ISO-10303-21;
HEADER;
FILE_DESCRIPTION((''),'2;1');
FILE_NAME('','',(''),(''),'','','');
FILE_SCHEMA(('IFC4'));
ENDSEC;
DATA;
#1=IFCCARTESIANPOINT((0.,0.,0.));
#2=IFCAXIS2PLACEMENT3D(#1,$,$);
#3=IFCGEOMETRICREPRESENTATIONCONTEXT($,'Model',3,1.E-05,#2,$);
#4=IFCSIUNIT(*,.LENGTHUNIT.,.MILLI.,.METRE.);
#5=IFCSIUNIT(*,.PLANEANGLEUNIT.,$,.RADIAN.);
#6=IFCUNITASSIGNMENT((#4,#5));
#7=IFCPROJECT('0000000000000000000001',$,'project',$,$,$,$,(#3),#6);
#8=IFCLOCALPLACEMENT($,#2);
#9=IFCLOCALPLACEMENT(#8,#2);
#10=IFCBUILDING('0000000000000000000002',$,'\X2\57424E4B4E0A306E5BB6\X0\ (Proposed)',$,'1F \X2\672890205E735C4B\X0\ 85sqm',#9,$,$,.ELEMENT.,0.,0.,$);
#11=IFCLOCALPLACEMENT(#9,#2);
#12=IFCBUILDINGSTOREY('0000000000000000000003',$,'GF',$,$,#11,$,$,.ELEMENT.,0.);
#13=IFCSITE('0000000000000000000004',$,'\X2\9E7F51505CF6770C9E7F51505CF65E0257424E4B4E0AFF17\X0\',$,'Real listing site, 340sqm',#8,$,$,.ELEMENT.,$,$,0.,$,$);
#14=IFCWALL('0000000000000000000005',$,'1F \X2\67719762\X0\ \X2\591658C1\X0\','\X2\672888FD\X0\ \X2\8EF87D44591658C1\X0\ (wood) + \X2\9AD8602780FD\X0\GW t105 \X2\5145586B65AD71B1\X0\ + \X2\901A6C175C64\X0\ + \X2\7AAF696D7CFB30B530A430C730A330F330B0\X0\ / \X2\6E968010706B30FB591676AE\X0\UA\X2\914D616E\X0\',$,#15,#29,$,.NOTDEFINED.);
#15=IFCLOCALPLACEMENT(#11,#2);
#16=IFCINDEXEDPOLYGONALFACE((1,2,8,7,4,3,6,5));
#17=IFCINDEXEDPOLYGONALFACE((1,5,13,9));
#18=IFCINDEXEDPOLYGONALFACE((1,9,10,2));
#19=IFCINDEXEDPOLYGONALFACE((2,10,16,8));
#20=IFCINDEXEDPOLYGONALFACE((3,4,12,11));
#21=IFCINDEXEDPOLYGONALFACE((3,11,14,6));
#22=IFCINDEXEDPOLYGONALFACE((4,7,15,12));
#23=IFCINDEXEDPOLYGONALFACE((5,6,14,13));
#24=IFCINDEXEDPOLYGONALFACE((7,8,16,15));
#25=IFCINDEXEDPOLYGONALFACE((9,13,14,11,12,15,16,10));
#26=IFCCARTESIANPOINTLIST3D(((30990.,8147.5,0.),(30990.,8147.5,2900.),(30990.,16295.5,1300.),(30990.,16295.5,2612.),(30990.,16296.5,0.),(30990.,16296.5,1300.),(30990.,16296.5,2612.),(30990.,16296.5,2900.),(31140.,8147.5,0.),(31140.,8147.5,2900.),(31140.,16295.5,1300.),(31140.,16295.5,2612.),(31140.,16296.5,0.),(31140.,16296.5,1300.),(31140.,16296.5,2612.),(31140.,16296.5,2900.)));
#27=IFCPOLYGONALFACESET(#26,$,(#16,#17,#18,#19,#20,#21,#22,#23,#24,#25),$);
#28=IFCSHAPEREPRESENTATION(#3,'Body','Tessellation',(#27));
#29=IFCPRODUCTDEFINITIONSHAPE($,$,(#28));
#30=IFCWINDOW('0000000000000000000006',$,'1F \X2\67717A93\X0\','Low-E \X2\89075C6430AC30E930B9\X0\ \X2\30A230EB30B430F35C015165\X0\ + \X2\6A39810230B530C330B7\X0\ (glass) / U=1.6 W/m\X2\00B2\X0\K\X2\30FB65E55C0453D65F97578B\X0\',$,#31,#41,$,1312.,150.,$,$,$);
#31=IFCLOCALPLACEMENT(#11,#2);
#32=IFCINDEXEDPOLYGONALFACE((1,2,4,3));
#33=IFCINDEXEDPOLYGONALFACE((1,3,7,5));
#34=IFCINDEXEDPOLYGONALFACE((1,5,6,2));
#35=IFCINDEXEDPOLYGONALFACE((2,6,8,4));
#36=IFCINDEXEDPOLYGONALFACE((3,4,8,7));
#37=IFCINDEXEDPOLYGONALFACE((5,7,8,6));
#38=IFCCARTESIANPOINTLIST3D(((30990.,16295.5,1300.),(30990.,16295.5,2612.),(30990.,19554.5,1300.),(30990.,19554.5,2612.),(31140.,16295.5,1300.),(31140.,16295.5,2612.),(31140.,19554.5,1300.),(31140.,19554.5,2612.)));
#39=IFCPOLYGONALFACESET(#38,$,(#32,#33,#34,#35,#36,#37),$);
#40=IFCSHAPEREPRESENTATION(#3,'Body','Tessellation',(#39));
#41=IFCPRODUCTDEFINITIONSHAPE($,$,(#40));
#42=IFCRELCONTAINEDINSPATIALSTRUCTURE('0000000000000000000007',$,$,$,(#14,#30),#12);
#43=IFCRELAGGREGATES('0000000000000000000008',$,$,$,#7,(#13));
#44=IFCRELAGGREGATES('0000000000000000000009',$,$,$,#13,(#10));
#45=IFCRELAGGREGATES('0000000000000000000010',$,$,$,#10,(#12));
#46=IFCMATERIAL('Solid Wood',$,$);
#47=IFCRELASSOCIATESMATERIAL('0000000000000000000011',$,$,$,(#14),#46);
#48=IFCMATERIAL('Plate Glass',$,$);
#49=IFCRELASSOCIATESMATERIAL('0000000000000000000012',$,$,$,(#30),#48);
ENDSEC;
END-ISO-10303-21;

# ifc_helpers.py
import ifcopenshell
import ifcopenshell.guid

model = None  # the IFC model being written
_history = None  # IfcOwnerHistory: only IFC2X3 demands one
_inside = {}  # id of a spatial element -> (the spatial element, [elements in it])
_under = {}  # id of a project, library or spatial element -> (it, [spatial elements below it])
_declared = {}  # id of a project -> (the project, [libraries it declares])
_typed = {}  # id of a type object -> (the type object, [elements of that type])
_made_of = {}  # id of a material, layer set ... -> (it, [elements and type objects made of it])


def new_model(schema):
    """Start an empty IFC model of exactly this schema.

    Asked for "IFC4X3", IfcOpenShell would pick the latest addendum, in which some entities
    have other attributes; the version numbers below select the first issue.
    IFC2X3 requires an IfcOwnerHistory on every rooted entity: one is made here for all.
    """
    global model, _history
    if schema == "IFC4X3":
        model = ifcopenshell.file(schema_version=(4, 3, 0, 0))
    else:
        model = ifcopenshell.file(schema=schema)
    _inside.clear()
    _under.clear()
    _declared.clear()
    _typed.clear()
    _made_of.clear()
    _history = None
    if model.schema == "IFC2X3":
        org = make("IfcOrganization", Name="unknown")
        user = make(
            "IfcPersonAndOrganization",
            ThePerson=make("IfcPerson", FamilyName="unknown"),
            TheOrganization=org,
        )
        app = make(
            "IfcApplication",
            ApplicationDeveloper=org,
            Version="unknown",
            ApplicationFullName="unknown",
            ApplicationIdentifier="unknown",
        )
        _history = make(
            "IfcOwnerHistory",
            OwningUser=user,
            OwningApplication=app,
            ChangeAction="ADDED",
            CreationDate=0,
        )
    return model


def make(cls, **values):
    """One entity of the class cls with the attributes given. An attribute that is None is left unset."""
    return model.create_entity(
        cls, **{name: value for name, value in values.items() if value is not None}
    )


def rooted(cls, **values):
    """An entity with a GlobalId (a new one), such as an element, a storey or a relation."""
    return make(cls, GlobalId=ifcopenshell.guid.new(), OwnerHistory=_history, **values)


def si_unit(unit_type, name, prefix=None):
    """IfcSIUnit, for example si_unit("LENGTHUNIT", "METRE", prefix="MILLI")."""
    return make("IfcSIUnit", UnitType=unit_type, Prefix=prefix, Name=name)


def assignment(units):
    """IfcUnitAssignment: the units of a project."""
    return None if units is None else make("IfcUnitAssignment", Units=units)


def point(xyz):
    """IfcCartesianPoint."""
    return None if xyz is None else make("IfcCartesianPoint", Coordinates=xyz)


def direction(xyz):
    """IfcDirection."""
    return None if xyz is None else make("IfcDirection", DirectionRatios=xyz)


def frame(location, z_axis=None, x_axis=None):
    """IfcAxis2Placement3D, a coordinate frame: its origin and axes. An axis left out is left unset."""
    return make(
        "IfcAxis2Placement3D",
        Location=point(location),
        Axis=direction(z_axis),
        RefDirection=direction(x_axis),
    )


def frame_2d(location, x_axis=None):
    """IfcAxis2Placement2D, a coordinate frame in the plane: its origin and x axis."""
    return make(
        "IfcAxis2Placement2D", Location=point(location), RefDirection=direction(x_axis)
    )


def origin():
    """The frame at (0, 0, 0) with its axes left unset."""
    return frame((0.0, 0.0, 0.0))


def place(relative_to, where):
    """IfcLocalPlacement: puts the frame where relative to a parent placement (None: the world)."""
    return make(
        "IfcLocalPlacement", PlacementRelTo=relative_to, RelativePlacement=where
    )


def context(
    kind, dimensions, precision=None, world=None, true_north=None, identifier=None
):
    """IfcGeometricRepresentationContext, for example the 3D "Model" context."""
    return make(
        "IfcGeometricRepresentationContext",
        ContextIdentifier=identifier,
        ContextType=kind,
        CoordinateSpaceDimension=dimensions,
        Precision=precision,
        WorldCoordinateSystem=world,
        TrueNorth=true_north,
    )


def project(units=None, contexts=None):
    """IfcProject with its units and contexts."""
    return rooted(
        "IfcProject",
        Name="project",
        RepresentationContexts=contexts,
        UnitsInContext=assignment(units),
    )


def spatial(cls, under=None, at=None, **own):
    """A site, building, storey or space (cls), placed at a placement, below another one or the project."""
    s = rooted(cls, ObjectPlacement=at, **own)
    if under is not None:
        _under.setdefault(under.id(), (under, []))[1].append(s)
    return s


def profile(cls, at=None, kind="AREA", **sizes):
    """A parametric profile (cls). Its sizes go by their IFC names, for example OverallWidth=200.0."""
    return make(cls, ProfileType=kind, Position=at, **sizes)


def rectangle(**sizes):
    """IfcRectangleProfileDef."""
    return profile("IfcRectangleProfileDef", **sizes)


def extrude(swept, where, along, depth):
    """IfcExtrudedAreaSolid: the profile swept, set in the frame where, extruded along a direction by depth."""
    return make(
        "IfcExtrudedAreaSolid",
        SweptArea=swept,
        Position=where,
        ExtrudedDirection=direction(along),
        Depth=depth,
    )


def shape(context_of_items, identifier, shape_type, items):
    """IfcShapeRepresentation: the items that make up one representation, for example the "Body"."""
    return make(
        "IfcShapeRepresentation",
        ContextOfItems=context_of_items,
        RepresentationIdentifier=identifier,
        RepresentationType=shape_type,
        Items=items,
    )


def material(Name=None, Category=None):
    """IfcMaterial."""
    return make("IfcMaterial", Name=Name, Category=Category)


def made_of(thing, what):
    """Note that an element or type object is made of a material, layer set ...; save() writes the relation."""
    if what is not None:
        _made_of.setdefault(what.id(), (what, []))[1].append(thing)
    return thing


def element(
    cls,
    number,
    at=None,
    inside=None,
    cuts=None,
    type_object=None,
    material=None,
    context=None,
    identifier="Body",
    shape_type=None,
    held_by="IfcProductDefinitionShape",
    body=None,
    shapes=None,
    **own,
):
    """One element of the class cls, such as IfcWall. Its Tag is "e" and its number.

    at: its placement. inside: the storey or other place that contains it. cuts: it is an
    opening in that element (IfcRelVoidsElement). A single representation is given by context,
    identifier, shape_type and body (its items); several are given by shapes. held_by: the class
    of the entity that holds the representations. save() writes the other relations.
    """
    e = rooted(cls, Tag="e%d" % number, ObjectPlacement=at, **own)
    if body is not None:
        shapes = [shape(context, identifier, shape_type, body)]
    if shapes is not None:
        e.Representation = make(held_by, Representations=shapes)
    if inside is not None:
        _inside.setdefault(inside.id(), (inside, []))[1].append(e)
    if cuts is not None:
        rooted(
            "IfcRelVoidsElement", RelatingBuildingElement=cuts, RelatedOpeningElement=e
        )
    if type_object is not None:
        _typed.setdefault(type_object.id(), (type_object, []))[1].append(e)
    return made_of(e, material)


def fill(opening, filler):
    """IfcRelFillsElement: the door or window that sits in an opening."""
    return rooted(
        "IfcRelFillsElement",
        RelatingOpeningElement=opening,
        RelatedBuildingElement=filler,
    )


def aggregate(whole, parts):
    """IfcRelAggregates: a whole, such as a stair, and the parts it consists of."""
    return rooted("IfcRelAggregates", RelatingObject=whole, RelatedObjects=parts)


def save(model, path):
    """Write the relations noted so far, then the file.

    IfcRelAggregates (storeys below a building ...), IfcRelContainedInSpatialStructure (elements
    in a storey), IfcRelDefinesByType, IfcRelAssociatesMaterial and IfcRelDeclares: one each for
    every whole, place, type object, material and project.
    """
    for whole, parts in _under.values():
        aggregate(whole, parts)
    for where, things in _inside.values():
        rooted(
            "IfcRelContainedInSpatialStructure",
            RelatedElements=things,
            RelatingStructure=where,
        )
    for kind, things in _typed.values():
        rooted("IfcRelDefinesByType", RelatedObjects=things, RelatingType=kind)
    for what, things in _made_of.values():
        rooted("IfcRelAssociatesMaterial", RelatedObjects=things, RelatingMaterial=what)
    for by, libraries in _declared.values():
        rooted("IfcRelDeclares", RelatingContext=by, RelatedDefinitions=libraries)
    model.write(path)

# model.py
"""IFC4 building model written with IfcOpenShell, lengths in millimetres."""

from ifc_helpers import new_model, si_unit, frame, frame_2d, origin, place, context, project, spatial, rectangle, extrude, material, element, fill, save


model = new_model("IFC4")

# Units and contexts
model_context = context("Model", 3, precision=1e-05, world=origin())
ifc_project = project(units=[si_unit("LENGTHUNIT", "METRE", prefix="MILLI"), si_unit("PLANEANGLEUNIT", "RADIAN")], contexts=[model_context])

# Site, building, storey
site_placement = place(None, origin())
site = spatial("IfcSite", under=ifc_project, at=site_placement, Name="鹿児島県鹿児島市坂之上７", ObjectType="Real listing site, 340sqm", CompositionType="ELEMENT", RefElevation=0.0)
building_placement = place(site_placement, origin())
building = spatial("IfcBuilding", under=site, at=building_placement, Name="坂之上の家 (Proposed)", ObjectType="1F 木造平屋 85sqm", CompositionType="ELEMENT", ElevationOfRefHeight=0.0, ElevationOfTerrain=0.0)
storey_placement = place(building_placement, origin())
storey = spatial("IfcBuildingStorey", under=building, at=storey_placement, Name="GF", CompositionType="ELEMENT", Elevation=0.0)

# Shared definitions
ifc_material_1 = material(Name="Solid Wood")

# Wall, opening, window
wall_1_placement = place(storey_placement, frame((15495.0, 4074.0, 0.0)))
wall_1 = element("IfcWall", 1, at=wall_1_placement, inside=storey, material=ifc_material_1, Name="1F 東面 外壁", Description="木製 軸組外壁 (wood) + 高性能GW t105 充填断熱 + 通気層 + 窯業系サイディング / 準耐火・外皮UA配慮", PredefinedType="NOTDEFINED", context=model_context, shape_type="SweptSolid", body=[
    extrude(rectangle(XDim=150.0, YDim=8149.0, at=frame_2d((75.0, 4074.0))), frame((15495.0, 4074.0, 0.0)), (0.0, 0.0, 1.0), 2900.0),
])
opening_placement = place(storey_placement, frame((15495.0, 8148.0, 650.0)))
opening = element("IfcOpeningElement", 2, at=opening_placement, cuts=wall_1, PredefinedType="NOTDEFINED", context=model_context, shape_type="SweptSolid", body=[
    extrude(rectangle(XDim=150.0, YDim=3259.0, at=frame_2d((75.0, 1629.0))), frame((15495.0, 8148.0, 650.0)), (0.0, 0.0, 1.0), 1312.0),
])
ifc_material_2 = material(Name="Plate Glass")
window_placement = place(storey_placement, frame((15495.0, 8148.0, 650.0)))
window = element("IfcWindow", 3, at=window_placement, inside=storey, material=ifc_material_2, Name="1F 東窓", Description="Low-E 複層ガラス アルゴン封入 + 樹脂サッシ (glass) / U=1.6 W/m²K・日射取得型", OverallHeight=1312.0, OverallWidth=150.0, context=model_context, shape_type="SweptSolid", body=[
    extrude(rectangle(XDim=150.0, YDim=3259.0, at=frame_2d((75.0, 1629.0))), frame((15495.0, 8148.0, 650.0)), (0.0, 0.0, 1.0), 1312.0),
])
fill(opening, window)

save(model, "model.ifc")
